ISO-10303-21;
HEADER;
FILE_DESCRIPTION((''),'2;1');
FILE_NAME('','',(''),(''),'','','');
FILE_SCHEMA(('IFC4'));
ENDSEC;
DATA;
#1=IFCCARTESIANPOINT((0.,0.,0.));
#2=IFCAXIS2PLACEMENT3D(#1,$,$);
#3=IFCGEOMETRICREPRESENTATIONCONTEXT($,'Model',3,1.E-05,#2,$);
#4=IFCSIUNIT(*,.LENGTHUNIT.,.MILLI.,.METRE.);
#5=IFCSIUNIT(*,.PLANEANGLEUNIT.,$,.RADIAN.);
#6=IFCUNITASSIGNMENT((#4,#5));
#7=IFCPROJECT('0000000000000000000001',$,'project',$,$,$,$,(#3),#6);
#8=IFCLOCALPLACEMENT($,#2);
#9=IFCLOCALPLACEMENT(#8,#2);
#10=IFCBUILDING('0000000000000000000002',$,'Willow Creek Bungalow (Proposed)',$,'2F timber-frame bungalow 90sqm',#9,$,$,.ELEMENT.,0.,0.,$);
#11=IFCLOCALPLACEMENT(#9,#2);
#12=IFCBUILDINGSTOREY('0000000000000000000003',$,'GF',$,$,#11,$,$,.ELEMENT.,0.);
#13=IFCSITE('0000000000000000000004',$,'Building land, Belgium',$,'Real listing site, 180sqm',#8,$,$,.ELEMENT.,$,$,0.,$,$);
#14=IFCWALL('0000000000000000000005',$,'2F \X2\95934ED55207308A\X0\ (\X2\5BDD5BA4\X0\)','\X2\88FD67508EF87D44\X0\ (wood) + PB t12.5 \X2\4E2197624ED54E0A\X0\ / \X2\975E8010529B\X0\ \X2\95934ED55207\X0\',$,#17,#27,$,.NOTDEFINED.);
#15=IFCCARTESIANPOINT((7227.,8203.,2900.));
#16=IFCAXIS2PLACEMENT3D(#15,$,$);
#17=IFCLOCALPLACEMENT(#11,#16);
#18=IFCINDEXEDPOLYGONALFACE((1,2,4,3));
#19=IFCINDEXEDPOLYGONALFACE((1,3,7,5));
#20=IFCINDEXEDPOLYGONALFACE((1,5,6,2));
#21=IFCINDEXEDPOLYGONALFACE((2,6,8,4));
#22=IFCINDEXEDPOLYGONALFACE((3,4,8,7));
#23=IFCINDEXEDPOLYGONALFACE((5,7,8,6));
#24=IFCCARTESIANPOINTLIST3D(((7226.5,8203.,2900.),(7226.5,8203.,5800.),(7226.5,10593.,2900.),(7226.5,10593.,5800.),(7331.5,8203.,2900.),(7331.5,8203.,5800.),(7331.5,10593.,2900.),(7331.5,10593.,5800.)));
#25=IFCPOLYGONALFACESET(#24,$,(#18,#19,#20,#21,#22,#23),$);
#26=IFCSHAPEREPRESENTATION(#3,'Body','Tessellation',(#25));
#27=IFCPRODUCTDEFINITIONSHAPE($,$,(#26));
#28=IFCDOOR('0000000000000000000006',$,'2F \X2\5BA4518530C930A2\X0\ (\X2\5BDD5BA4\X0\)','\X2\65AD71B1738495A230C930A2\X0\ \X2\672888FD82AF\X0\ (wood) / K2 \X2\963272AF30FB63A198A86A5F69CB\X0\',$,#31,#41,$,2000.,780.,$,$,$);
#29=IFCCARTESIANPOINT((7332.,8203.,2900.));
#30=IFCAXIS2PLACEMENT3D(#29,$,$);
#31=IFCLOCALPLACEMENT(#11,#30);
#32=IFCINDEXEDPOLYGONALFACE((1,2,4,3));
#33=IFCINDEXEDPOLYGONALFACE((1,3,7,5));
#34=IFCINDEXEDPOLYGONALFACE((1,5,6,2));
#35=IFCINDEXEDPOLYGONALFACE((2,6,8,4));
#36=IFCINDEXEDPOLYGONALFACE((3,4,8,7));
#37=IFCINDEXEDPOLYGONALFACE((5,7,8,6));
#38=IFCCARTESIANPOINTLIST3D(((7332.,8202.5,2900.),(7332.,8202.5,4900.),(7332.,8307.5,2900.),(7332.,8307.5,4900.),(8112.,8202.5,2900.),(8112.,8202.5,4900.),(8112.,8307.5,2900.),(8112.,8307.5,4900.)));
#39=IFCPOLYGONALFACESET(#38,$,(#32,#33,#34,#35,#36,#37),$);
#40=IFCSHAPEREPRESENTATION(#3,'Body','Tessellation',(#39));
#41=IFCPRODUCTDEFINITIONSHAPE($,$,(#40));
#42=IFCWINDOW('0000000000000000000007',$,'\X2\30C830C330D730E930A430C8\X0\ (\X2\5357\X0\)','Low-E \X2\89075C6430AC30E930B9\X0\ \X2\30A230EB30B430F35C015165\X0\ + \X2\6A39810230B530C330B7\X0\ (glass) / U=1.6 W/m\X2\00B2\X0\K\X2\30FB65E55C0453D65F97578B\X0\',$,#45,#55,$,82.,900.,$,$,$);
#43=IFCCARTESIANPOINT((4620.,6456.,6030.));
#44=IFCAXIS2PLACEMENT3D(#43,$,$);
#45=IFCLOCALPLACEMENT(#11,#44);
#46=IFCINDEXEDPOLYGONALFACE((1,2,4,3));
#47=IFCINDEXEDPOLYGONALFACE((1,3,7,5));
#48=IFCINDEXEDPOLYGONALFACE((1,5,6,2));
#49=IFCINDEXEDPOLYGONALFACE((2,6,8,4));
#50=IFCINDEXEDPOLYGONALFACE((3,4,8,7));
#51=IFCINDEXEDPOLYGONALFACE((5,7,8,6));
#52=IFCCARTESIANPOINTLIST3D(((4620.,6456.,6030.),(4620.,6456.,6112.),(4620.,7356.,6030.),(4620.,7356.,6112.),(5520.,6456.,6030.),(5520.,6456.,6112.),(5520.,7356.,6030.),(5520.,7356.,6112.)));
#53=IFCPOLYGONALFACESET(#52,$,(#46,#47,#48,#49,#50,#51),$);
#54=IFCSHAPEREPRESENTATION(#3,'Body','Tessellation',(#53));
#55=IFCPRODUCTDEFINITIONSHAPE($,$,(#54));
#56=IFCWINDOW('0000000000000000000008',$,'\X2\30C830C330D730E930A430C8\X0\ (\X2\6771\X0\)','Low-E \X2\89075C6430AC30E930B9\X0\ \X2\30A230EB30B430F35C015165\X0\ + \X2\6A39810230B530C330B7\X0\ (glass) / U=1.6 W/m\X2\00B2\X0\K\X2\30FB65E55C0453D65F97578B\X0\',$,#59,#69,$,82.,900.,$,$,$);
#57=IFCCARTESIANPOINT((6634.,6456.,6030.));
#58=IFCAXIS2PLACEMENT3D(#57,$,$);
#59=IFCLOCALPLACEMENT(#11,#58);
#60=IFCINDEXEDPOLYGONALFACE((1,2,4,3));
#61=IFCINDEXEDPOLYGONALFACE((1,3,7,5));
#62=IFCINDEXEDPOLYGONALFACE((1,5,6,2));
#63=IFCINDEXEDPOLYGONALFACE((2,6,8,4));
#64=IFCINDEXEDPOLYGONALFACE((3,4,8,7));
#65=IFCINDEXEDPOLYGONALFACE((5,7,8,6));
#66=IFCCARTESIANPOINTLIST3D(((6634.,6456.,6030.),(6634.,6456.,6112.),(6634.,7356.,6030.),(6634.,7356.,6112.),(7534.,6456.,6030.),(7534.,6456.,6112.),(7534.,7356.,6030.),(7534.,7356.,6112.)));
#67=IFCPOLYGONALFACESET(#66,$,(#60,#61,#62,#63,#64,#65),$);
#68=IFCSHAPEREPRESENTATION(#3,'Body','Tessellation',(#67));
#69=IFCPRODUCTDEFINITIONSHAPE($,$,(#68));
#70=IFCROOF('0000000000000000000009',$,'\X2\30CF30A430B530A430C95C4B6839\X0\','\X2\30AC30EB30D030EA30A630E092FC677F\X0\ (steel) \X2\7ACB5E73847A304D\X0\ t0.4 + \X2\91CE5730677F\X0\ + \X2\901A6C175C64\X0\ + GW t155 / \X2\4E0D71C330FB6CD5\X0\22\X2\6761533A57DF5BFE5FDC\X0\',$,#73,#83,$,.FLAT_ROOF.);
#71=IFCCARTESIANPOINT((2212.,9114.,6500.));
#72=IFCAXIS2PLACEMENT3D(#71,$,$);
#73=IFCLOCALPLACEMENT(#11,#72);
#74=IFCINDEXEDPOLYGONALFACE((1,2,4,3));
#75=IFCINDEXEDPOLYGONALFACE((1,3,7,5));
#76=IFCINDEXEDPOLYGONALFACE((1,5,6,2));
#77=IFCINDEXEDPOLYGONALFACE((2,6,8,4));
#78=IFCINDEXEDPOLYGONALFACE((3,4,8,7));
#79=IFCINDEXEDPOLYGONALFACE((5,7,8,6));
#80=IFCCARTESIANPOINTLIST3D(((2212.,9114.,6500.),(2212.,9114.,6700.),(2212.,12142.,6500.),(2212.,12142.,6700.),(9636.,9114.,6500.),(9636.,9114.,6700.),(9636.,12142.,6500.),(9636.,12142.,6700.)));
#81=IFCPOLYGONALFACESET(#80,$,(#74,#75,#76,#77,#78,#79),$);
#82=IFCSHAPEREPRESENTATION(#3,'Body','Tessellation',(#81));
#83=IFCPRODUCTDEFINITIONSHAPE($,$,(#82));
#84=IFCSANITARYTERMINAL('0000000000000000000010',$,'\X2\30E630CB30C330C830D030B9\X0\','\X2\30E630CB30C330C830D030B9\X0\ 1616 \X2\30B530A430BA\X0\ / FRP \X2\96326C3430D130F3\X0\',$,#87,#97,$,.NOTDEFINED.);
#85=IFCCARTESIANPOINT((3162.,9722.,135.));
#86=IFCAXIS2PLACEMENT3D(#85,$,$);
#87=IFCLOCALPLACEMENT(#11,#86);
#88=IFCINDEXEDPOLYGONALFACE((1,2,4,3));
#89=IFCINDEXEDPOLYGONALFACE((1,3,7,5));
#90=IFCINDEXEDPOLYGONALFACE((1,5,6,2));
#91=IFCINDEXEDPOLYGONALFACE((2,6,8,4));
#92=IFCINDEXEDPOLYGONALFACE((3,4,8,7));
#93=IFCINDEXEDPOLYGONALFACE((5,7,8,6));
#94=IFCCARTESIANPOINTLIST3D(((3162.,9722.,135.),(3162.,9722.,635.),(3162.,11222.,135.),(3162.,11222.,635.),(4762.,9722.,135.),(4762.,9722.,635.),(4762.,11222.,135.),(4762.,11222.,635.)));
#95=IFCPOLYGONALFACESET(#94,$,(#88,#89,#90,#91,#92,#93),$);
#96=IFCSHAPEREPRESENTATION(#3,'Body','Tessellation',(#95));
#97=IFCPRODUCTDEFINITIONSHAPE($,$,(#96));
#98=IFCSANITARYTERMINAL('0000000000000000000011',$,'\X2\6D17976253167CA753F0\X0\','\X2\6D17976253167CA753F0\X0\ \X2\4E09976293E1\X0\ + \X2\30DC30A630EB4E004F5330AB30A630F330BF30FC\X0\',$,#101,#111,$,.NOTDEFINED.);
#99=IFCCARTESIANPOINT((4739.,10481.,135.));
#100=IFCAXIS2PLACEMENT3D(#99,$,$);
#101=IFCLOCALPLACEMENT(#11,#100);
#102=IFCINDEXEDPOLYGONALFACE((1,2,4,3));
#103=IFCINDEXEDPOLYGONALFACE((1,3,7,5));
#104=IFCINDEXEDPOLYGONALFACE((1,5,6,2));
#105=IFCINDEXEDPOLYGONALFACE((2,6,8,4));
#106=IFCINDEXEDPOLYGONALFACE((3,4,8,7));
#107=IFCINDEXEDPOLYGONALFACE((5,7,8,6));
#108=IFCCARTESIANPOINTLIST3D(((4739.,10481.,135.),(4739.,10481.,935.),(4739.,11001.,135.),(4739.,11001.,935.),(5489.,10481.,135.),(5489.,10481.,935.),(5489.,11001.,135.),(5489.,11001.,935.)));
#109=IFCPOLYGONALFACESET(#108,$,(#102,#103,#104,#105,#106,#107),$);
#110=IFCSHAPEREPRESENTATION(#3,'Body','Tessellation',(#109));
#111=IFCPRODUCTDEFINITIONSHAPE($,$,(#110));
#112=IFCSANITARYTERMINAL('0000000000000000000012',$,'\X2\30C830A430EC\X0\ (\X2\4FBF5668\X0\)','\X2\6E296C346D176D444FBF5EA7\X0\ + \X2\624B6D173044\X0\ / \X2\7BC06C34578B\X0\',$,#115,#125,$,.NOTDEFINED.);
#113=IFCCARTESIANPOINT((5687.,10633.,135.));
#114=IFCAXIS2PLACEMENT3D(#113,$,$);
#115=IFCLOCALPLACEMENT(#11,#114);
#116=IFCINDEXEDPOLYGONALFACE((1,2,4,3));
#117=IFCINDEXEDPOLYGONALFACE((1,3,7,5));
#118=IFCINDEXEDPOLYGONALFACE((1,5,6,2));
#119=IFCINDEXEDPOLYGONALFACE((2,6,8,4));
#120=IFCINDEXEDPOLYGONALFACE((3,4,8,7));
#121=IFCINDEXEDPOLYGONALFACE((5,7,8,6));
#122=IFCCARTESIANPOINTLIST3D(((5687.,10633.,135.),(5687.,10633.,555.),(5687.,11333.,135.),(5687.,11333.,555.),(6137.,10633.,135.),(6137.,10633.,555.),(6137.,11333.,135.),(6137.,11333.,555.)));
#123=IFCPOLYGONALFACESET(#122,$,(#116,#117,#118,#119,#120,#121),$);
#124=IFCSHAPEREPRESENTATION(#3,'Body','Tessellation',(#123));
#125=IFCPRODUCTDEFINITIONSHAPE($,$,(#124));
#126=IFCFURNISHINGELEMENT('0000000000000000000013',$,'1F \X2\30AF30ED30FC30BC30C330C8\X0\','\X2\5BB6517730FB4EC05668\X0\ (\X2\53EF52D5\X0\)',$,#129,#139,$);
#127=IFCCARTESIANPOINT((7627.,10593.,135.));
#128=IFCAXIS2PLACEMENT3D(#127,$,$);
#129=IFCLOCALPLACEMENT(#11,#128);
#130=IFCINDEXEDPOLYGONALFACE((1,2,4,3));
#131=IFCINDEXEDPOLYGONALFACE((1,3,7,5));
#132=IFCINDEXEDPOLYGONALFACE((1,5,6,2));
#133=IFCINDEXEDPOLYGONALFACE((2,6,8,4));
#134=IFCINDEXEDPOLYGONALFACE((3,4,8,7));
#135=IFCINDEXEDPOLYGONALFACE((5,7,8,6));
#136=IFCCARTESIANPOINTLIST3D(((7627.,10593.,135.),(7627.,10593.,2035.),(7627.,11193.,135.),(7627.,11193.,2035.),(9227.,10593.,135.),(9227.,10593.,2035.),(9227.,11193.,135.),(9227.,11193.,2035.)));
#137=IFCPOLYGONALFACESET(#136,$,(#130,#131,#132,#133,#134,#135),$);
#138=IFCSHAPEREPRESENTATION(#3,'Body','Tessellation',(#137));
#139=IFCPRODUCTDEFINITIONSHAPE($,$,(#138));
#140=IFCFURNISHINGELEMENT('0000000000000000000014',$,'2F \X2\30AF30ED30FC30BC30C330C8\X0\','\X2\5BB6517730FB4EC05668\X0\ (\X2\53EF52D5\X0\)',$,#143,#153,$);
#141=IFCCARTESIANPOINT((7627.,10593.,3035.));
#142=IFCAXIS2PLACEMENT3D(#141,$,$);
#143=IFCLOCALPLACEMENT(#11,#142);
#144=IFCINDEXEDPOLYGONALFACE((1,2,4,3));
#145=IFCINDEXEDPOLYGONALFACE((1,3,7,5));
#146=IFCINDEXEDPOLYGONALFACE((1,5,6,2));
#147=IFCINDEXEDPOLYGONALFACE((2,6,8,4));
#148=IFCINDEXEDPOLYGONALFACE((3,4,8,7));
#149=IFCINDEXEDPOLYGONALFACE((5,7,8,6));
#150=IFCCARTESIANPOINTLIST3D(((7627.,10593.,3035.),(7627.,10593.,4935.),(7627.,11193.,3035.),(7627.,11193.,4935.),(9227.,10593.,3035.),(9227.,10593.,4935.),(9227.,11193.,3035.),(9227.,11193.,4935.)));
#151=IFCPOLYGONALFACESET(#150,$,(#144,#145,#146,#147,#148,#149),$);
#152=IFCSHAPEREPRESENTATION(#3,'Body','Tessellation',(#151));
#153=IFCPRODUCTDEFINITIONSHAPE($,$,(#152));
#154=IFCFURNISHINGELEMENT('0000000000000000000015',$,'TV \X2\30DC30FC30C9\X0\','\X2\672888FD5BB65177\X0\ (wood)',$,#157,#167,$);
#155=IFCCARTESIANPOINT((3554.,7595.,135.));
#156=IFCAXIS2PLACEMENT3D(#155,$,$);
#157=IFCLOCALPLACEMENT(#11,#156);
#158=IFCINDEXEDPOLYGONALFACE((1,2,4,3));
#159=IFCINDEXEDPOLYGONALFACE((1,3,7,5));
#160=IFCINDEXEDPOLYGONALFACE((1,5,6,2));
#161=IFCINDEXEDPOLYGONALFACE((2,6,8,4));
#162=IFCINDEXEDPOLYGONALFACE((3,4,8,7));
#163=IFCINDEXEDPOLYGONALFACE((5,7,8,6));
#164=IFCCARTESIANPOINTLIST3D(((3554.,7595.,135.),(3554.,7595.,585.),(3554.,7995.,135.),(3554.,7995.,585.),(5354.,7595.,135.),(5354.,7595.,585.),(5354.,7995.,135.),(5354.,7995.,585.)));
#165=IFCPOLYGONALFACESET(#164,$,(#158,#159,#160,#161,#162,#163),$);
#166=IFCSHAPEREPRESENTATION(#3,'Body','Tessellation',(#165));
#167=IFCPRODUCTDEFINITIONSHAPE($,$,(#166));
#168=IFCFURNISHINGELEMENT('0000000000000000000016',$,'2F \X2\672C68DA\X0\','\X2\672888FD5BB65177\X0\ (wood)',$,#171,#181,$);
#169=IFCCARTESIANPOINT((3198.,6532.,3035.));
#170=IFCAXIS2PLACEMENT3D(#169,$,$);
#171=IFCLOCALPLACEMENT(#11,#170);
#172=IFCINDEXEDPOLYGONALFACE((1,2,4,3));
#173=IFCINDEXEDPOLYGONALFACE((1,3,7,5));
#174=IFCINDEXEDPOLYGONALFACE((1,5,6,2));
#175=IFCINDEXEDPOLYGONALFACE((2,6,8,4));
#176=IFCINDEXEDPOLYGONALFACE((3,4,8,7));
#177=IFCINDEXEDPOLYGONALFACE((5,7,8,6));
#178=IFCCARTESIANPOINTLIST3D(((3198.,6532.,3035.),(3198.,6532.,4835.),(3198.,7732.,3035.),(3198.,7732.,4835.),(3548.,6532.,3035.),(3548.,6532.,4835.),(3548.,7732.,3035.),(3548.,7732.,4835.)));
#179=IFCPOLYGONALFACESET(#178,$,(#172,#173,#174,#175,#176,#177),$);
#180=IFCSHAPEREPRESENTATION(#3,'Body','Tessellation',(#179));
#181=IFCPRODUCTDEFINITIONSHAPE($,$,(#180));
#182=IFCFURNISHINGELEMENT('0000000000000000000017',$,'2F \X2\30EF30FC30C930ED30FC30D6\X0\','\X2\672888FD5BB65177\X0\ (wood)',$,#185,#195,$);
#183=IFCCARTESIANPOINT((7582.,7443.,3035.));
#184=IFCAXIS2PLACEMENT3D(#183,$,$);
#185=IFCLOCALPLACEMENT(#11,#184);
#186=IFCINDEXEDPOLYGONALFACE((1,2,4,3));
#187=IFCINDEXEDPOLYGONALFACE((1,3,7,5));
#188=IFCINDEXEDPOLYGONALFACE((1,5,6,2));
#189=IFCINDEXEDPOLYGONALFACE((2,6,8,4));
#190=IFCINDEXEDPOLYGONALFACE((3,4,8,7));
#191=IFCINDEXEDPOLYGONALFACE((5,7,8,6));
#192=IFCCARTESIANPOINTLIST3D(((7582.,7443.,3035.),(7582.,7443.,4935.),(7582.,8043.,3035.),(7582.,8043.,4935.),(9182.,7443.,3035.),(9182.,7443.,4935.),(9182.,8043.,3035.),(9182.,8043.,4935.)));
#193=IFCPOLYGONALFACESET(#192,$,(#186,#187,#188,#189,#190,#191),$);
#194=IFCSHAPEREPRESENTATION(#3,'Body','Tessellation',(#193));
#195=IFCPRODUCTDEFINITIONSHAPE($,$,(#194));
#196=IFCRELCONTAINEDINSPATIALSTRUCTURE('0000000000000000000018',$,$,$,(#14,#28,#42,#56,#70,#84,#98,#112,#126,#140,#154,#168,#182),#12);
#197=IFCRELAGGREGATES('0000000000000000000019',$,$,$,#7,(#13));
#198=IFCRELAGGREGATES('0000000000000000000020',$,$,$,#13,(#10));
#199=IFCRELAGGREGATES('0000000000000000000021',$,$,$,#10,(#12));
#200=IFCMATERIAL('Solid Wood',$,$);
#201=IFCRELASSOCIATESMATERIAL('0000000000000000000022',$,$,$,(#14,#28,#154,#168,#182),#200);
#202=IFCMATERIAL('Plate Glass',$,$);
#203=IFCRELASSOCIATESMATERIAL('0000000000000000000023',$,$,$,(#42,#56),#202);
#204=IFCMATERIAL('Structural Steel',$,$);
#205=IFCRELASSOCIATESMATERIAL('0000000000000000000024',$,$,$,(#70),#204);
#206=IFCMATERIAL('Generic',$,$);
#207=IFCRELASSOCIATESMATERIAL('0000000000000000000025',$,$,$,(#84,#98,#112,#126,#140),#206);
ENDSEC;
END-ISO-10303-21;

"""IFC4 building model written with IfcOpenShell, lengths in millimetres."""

from ifc_helpers import new_model, si_unit, frame, frame_2d, origin, place, context, project, spatial, rectangle, extrude, material, element, save


model = new_model("IFC4")

# Units and contexts
model_context = context("Model", 3, precision=1e-05, world=origin())
ifc_project = project(units=[si_unit("LENGTHUNIT", "METRE", prefix="MILLI"), si_unit("PLANEANGLEUNIT", "RADIAN")], contexts=[model_context])

# Site, building, storey
site_placement = place(None, origin())
site = spatial("IfcSite", under=ifc_project, at=site_placement, Name="Building land, Belgium", ObjectType="Real listing site, 180sqm", CompositionType="ELEMENT", RefElevation=0.0)
building_placement = place(site_placement, origin())
building = spatial("IfcBuilding", under=site, at=building_placement, Name="Willow Creek Bungalow (Proposed)", ObjectType="2F timber-frame bungalow 90sqm", CompositionType="ELEMENT", ElevationOfRefHeight=0.0, ElevationOfTerrain=0.0)
storey_placement = place(building_placement, origin())
storey = spatial("IfcBuildingStorey", under=building, at=storey_placement, Name="GF", CompositionType="ELEMENT", Elevation=0.0)

# Shared definitions
ifc_material_1 = material(Name="Solid Wood")
ifc_material_2 = material(Name="Plate Glass")

# Wall
wall_1_placement = place(storey_placement, frame((7227.0, 8203.0, 2900.0)))
element("IfcWall", 1, at=wall_1_placement, inside=storey, material=ifc_material_1, Name="2F 間仕切り (寝室)", Description="製材軸組 (wood) + PB t12.5 両面仕上 / 非耐力 間仕切", PredefinedType="NOTDEFINED", context=model_context, shape_type="SweptSolid", body=[
    extrude(rectangle(XDim=105.0, YDim=2390.0, at=frame_2d((52.0, 1195.0))), frame((7227.0, 8203.0, 2900.0)), (0.0, 0.0, 1.0), 2900.0),
])

# Door
door_1_placement = place(storey_placement, frame((7332.0, 8203.0, 2900.0)))
element("IfcDoor", 2, at=door_1_placement, inside=storey, material=ifc_material_1, Name="2F 室内ドア (寝室)", Description="断熱玄関ドア 木製芯 (wood) / K2 防犯・採風機構", OverallHeight=2000.0, OverallWidth=780.0, context=model_context, shape_type="SweptSolid", body=[
    extrude(rectangle(XDim=780.0, YDim=105.0, at=frame_2d((390.0, 52.0))), frame((7332.0, 8203.0, 2900.0)), (0.0, 0.0, 1.0), 2000.0),
])

# Windows
window_1_placement = place(storey_placement, frame((4620.0, 6456.0, 6030.0)))
element("IfcWindow", 3, at=window_1_placement, inside=storey, material=ifc_material_2, Name="トップライト (南)", Description="Low-E 複層ガラス アルゴン封入 + 樹脂サッシ (glass) / U=1.6 W/m²K・日射取得型", OverallHeight=82.0, OverallWidth=900.0, context=model_context, shape_type="SweptSolid", body=[
    extrude(rectangle(XDim=900.0, YDim=900.0, at=frame_2d((450.0, 450.0))), frame((4620.0, 6456.0, 6030.0)), (0.0, 0.0, 1.0), 82.0),
])
window_2_placement = place(storey_placement, frame((6634.0, 6456.0, 6030.0)))
element("IfcWindow", 4, at=window_2_placement, inside=storey, material=ifc_material_2, Name="トップライト (東)", Description="Low-E 複層ガラス アルゴン封入 + 樹脂サッシ (glass) / U=1.6 W/m²K・日射取得型", OverallHeight=82.0, OverallWidth=900.0, context=model_context, shape_type="SweptSolid", body=[
    extrude(rectangle(XDim=900.0, YDim=900.0, at=frame_2d((450.0, 450.0))), frame((6634.0, 6456.0, 6030.0)), (0.0, 0.0, 1.0), 82.0),
])

# Roof
ifc_material_3 = material(Name="Structural Steel")
roof_placement = place(storey_placement, frame((2212.0, 9114.0, 6500.0)))
element("IfcRoof", 5, at=roof_placement, inside=storey, material=ifc_material_3, Name="ハイサイド屋根", Description="ガルバリウム鋼板 (steel) 立平葺き t0.4 + 野地板 + 通気層 + GW t155 / 不燃・法22条区域対応", PredefinedType="FLAT_ROOF", context=model_context, shape_type="SweptSolid", body=[
    extrude(rectangle(XDim=7424.0, YDim=3028.0, at=frame_2d((3712.0, 1514.0))), frame((2212.0, 9114.0, 6500.0)), (0.0, 0.0, 1.0), 200.0),
])

# Sanitary terminals
ifc_material_4 = material(Name="Generic")
sanitary_terminal_1_placement = place(storey_placement, frame((3162.0, 9722.0, 135.0)))
element("IfcSanitaryTerminal", 6, at=sanitary_terminal_1_placement, inside=storey, material=ifc_material_4, Name="ユニットバス", Description="ユニットバス 1616 サイズ / FRP 防水パン", PredefinedType="NOTDEFINED", context=model_context, shape_type="SweptSolid", body=[
    extrude(rectangle(XDim=1600.0, YDim=1500.0, at=frame_2d((800.0, 750.0))), frame((3162.0, 9722.0, 135.0)), (0.0, 0.0, 1.0), 500.0),
])
sanitary_terminal_2_placement = place(storey_placement, frame((4739.0, 10481.0, 135.0)))
element("IfcSanitaryTerminal", 7, at=sanitary_terminal_2_placement, inside=storey, material=ifc_material_4, Name="洗面化粧台", Description="洗面化粧台 三面鏡 + ボウル一体カウンター", PredefinedType="NOTDEFINED", context=model_context, shape_type="SweptSolid", body=[
    extrude(rectangle(XDim=750.0, YDim=520.0, at=frame_2d((375.0, 260.0))), frame((4739.0, 10481.0, 135.0)), (0.0, 0.0, 1.0), 800.0),
])
sanitary_terminal_3_placement = place(storey_placement, frame((5687.0, 10633.0, 135.0)))
element("IfcSanitaryTerminal", 8, at=sanitary_terminal_3_placement, inside=storey, material=ifc_material_4, Name="トイレ (便器)", Description="温水洗浄便座 + 手洗い / 節水型", PredefinedType="NOTDEFINED", context=model_context, shape_type="SweptSolid", body=[
    extrude(rectangle(XDim=450.0, YDim=700.0, at=frame_2d((225.0, 350.0))), frame((5687.0, 10633.0, 135.0)), (0.0, 0.0, 1.0), 420.0),
])

# Furnishing elements
furnishing_1_placement = place(storey_placement, frame((7627.0, 10593.0, 135.0)))
element("IfcFurnishingElement", 9, at=furnishing_1_placement, inside=storey, material=ifc_material_4, Name="1F クローゼット", Description="家具・什器 (可動)", context=model_context, shape_type="SweptSolid", body=[
    extrude(rectangle(XDim=1600.0, YDim=600.0, at=frame_2d((800.0, 300.0))), frame((7627.0, 10593.0, 135.0)), (0.0, 0.0, 1.0), 1900.0),
])
furnishing_2_placement = place(storey_placement, frame((7627.0, 10593.0, 3035.0)))
element("IfcFurnishingElement", 10, at=furnishing_2_placement, inside=storey, material=ifc_material_4, Name="2F クローゼット", Description="家具・什器 (可動)", context=model_context, shape_type="SweptSolid", body=[
    extrude(rectangle(XDim=1600.0, YDim=600.0, at=frame_2d((800.0, 300.0))), frame((7627.0, 10593.0, 3035.0)), (0.0, 0.0, 1.0), 1900.0),
])
furnishing_3_placement = place(storey_placement, frame((3554.0, 7595.0, 135.0)))
element("IfcFurnishingElement", 11, at=furnishing_3_placement, inside=storey, material=ifc_material_1, Name="TV ボード", Description="木製家具 (wood)", context=model_context, shape_type="SweptSolid", body=[
    extrude(rectangle(XDim=1800.0, YDim=400.0, at=frame_2d((900.0, 200.0))), frame((3554.0, 7595.0, 135.0)), (0.0, 0.0, 1.0), 450.0),
])
furnishing_4_placement = place(storey_placement, frame((3198.0, 6532.0, 3035.0)))
element("IfcFurnishingElement", 12, at=furnishing_4_placement, inside=storey, material=ifc_material_1, Name="2F 本棚", Description="木製家具 (wood)", context=model_context, shape_type="SweptSolid", body=[
    extrude(rectangle(XDim=350.0, YDim=1200.0, at=frame_2d((175.0, 600.0))), frame((3198.0, 6532.0, 3035.0)), (0.0, 0.0, 1.0), 1800.0),
])
furnishing_5_placement = place(storey_placement, frame((7582.0, 7443.0, 3035.0)))
element("IfcFurnishingElement", 13, at=furnishing_5_placement, inside=storey, material=ifc_material_1, Name="2F ワードローブ", Description="木製家具 (wood)", context=model_context, shape_type="SweptSolid", body=[
    extrude(rectangle(XDim=1600.0, YDim=600.0, at=frame_2d((800.0, 300.0))), frame((7582.0, 7443.0, 3035.0)), (0.0, 0.0, 1.0), 1900.0),
])

save(model, "model.ifc")
